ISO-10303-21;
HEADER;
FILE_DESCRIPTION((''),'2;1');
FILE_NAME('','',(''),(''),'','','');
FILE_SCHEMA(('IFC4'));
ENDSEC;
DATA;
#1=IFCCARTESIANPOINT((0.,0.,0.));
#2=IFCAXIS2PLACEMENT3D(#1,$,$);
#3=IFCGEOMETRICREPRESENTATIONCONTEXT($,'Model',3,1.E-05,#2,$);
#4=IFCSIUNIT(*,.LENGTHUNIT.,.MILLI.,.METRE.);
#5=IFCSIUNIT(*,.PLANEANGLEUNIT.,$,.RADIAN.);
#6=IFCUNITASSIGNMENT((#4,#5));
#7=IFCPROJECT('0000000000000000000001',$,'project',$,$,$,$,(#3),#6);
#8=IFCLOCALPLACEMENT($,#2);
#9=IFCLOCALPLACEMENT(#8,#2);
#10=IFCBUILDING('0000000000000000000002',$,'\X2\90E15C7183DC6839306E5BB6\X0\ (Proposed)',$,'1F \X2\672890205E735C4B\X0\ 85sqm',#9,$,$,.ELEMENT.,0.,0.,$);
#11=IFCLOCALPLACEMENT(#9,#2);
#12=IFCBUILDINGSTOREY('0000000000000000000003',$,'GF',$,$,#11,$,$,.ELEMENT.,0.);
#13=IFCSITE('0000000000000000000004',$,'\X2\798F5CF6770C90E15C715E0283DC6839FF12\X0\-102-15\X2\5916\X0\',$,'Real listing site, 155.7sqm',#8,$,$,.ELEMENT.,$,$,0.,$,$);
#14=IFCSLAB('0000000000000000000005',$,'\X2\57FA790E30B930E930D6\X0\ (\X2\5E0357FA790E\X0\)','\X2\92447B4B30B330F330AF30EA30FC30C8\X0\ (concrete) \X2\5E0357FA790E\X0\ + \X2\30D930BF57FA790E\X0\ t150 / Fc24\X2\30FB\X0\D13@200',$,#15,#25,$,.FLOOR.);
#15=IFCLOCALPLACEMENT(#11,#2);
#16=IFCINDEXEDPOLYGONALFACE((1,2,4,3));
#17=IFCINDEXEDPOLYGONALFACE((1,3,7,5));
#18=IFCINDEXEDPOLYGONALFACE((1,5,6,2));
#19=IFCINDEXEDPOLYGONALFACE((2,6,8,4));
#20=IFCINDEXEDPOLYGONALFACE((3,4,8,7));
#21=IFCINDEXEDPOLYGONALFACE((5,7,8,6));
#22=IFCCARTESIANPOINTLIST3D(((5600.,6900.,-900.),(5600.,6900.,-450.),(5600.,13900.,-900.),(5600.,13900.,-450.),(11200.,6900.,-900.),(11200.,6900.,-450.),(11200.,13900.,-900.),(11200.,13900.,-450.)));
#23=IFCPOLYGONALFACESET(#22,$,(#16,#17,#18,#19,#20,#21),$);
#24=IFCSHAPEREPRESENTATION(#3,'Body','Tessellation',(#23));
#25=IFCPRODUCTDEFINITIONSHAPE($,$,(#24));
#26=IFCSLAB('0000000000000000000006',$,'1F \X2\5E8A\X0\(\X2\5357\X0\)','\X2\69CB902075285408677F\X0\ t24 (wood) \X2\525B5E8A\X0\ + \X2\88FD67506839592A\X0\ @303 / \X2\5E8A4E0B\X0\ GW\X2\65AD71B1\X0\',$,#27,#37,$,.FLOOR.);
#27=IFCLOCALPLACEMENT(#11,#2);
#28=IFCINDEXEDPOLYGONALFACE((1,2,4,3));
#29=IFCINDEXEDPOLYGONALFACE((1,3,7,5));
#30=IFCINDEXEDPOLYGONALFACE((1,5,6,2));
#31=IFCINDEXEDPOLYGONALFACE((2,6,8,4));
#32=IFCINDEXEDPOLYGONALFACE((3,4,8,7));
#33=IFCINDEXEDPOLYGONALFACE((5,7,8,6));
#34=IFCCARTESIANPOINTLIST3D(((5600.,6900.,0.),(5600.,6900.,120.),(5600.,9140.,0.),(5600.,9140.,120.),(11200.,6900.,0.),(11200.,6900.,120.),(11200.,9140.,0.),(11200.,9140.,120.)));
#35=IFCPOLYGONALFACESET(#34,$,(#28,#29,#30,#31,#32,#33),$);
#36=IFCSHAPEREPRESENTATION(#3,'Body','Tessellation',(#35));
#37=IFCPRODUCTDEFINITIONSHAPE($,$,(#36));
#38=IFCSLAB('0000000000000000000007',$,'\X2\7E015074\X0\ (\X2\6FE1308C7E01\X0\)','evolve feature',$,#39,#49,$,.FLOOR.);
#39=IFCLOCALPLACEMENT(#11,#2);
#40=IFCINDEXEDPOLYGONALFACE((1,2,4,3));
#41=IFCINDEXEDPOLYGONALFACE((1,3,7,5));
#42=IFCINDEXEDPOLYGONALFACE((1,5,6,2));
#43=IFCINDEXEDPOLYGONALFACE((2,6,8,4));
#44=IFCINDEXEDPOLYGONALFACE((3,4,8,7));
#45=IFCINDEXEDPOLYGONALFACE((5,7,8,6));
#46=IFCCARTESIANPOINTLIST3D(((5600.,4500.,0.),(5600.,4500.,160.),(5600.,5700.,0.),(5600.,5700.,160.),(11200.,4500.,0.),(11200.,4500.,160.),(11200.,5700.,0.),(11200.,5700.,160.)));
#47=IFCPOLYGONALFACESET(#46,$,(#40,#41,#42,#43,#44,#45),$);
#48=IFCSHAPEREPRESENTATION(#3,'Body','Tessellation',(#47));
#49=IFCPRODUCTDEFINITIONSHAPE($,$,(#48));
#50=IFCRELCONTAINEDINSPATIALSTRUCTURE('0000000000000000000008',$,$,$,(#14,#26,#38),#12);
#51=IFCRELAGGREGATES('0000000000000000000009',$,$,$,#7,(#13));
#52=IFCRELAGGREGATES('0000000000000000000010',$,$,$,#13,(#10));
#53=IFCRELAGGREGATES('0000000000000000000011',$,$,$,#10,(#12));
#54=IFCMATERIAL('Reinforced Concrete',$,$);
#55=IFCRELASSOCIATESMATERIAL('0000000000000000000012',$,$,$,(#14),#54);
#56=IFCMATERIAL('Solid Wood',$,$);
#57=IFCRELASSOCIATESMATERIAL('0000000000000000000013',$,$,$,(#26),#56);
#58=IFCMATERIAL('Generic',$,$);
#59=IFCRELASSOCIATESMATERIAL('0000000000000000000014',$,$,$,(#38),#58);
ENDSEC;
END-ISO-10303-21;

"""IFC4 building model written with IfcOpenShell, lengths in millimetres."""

from ifc_helpers import new_model, si_unit, frame, frame_2d, origin, place, context, project, spatial, rectangle, extrude, material, element, save


model = new_model("IFC4")

# Units and contexts
model_context = context("Model", 3, precision=1e-05, world=origin())
ifc_project = project(units=[si_unit("LENGTHUNIT", "METRE", prefix="MILLI"), si_unit("PLANEANGLEUNIT", "RADIAN")], contexts=[model_context])

# Site, building, storey
site_placement = place(None, origin())
site = spatial("IfcSite", under=ifc_project, at=site_placement, Name="福島県郡山市菜根２-102-15外", ObjectType="Real listing site, 155.7sqm", CompositionType="ELEMENT", RefElevation=0.0)
building_placement = place(site_placement, origin())
building = spatial("IfcBuilding", under=site, at=building_placement, Name="郡山菜根の家 (Proposed)", ObjectType="1F 木造平屋 85sqm", CompositionType="ELEMENT", ElevationOfRefHeight=0.0, ElevationOfTerrain=0.0)
storey_placement = place(building_placement, origin())
storey = spatial("IfcBuildingStorey", under=building, at=storey_placement, Name="GF", CompositionType="ELEMENT", Elevation=0.0)

# Slabs
ifc_material_1 = material(Name="Reinforced Concrete")
slab_1_placement = place(storey_placement, frame((2800.0, 3450.0, -450.0)))
element("IfcSlab", 1, at=slab_1_placement, inside=storey, material=ifc_material_1, Name="基礎スラブ (布基礎)", Description="鉄筋コンクリート (concrete) 布基礎 + ベタ基礎 t150 / Fc24・D13@200", PredefinedType="FLOOR", context=model_context, shape_type="SweptSolid", body=[
    extrude(rectangle(XDim=5600.0, YDim=7000.0, at=frame_2d((2800.0, 3500.0))), frame((2800.0, 3450.0, -450.0)), (0.0, 0.0, 1.0), 450.0),
])
ifc_material_2 = material(Name="Solid Wood")
slab_2_placement = place(storey_placement, frame((2800.0, 3450.0, 0.0)))
element("IfcSlab", 2, at=slab_2_placement, inside=storey, material=ifc_material_2, Name="1F 床(南)", Description="構造用合板 t24 (wood) 剛床 + 製材根太 @303 / 床下 GW断熱", PredefinedType="FLOOR", context=model_context, shape_type="SweptSolid", body=[
    extrude(rectangle(XDim=5600.0, YDim=2240.0, at=frame_2d((2800.0, 1120.0))), frame((2800.0, 3450.0, 0.0)), (0.0, 0.0, 1.0), 120.0),
])
ifc_material_3 = material(Name="Generic")
slab_3_placement = place(storey_placement, frame((2800.0, 2250.0, 0.0)))
element("IfcSlab", 3, at=slab_3_placement, inside=storey, material=ifc_material_3, Name="縁側 (濡れ縁)", Description="evolve feature", PredefinedType="FLOOR", context=model_context, shape_type="SweptSolid", body=[
    extrude(rectangle(XDim=5600.0, YDim=1200.0, at=frame_2d((2800.0, 600.0))), frame((2800.0, 2250.0, 0.0)), (0.0, 0.0, 1.0), 160.0),
])

save(model, "model.ifc")
